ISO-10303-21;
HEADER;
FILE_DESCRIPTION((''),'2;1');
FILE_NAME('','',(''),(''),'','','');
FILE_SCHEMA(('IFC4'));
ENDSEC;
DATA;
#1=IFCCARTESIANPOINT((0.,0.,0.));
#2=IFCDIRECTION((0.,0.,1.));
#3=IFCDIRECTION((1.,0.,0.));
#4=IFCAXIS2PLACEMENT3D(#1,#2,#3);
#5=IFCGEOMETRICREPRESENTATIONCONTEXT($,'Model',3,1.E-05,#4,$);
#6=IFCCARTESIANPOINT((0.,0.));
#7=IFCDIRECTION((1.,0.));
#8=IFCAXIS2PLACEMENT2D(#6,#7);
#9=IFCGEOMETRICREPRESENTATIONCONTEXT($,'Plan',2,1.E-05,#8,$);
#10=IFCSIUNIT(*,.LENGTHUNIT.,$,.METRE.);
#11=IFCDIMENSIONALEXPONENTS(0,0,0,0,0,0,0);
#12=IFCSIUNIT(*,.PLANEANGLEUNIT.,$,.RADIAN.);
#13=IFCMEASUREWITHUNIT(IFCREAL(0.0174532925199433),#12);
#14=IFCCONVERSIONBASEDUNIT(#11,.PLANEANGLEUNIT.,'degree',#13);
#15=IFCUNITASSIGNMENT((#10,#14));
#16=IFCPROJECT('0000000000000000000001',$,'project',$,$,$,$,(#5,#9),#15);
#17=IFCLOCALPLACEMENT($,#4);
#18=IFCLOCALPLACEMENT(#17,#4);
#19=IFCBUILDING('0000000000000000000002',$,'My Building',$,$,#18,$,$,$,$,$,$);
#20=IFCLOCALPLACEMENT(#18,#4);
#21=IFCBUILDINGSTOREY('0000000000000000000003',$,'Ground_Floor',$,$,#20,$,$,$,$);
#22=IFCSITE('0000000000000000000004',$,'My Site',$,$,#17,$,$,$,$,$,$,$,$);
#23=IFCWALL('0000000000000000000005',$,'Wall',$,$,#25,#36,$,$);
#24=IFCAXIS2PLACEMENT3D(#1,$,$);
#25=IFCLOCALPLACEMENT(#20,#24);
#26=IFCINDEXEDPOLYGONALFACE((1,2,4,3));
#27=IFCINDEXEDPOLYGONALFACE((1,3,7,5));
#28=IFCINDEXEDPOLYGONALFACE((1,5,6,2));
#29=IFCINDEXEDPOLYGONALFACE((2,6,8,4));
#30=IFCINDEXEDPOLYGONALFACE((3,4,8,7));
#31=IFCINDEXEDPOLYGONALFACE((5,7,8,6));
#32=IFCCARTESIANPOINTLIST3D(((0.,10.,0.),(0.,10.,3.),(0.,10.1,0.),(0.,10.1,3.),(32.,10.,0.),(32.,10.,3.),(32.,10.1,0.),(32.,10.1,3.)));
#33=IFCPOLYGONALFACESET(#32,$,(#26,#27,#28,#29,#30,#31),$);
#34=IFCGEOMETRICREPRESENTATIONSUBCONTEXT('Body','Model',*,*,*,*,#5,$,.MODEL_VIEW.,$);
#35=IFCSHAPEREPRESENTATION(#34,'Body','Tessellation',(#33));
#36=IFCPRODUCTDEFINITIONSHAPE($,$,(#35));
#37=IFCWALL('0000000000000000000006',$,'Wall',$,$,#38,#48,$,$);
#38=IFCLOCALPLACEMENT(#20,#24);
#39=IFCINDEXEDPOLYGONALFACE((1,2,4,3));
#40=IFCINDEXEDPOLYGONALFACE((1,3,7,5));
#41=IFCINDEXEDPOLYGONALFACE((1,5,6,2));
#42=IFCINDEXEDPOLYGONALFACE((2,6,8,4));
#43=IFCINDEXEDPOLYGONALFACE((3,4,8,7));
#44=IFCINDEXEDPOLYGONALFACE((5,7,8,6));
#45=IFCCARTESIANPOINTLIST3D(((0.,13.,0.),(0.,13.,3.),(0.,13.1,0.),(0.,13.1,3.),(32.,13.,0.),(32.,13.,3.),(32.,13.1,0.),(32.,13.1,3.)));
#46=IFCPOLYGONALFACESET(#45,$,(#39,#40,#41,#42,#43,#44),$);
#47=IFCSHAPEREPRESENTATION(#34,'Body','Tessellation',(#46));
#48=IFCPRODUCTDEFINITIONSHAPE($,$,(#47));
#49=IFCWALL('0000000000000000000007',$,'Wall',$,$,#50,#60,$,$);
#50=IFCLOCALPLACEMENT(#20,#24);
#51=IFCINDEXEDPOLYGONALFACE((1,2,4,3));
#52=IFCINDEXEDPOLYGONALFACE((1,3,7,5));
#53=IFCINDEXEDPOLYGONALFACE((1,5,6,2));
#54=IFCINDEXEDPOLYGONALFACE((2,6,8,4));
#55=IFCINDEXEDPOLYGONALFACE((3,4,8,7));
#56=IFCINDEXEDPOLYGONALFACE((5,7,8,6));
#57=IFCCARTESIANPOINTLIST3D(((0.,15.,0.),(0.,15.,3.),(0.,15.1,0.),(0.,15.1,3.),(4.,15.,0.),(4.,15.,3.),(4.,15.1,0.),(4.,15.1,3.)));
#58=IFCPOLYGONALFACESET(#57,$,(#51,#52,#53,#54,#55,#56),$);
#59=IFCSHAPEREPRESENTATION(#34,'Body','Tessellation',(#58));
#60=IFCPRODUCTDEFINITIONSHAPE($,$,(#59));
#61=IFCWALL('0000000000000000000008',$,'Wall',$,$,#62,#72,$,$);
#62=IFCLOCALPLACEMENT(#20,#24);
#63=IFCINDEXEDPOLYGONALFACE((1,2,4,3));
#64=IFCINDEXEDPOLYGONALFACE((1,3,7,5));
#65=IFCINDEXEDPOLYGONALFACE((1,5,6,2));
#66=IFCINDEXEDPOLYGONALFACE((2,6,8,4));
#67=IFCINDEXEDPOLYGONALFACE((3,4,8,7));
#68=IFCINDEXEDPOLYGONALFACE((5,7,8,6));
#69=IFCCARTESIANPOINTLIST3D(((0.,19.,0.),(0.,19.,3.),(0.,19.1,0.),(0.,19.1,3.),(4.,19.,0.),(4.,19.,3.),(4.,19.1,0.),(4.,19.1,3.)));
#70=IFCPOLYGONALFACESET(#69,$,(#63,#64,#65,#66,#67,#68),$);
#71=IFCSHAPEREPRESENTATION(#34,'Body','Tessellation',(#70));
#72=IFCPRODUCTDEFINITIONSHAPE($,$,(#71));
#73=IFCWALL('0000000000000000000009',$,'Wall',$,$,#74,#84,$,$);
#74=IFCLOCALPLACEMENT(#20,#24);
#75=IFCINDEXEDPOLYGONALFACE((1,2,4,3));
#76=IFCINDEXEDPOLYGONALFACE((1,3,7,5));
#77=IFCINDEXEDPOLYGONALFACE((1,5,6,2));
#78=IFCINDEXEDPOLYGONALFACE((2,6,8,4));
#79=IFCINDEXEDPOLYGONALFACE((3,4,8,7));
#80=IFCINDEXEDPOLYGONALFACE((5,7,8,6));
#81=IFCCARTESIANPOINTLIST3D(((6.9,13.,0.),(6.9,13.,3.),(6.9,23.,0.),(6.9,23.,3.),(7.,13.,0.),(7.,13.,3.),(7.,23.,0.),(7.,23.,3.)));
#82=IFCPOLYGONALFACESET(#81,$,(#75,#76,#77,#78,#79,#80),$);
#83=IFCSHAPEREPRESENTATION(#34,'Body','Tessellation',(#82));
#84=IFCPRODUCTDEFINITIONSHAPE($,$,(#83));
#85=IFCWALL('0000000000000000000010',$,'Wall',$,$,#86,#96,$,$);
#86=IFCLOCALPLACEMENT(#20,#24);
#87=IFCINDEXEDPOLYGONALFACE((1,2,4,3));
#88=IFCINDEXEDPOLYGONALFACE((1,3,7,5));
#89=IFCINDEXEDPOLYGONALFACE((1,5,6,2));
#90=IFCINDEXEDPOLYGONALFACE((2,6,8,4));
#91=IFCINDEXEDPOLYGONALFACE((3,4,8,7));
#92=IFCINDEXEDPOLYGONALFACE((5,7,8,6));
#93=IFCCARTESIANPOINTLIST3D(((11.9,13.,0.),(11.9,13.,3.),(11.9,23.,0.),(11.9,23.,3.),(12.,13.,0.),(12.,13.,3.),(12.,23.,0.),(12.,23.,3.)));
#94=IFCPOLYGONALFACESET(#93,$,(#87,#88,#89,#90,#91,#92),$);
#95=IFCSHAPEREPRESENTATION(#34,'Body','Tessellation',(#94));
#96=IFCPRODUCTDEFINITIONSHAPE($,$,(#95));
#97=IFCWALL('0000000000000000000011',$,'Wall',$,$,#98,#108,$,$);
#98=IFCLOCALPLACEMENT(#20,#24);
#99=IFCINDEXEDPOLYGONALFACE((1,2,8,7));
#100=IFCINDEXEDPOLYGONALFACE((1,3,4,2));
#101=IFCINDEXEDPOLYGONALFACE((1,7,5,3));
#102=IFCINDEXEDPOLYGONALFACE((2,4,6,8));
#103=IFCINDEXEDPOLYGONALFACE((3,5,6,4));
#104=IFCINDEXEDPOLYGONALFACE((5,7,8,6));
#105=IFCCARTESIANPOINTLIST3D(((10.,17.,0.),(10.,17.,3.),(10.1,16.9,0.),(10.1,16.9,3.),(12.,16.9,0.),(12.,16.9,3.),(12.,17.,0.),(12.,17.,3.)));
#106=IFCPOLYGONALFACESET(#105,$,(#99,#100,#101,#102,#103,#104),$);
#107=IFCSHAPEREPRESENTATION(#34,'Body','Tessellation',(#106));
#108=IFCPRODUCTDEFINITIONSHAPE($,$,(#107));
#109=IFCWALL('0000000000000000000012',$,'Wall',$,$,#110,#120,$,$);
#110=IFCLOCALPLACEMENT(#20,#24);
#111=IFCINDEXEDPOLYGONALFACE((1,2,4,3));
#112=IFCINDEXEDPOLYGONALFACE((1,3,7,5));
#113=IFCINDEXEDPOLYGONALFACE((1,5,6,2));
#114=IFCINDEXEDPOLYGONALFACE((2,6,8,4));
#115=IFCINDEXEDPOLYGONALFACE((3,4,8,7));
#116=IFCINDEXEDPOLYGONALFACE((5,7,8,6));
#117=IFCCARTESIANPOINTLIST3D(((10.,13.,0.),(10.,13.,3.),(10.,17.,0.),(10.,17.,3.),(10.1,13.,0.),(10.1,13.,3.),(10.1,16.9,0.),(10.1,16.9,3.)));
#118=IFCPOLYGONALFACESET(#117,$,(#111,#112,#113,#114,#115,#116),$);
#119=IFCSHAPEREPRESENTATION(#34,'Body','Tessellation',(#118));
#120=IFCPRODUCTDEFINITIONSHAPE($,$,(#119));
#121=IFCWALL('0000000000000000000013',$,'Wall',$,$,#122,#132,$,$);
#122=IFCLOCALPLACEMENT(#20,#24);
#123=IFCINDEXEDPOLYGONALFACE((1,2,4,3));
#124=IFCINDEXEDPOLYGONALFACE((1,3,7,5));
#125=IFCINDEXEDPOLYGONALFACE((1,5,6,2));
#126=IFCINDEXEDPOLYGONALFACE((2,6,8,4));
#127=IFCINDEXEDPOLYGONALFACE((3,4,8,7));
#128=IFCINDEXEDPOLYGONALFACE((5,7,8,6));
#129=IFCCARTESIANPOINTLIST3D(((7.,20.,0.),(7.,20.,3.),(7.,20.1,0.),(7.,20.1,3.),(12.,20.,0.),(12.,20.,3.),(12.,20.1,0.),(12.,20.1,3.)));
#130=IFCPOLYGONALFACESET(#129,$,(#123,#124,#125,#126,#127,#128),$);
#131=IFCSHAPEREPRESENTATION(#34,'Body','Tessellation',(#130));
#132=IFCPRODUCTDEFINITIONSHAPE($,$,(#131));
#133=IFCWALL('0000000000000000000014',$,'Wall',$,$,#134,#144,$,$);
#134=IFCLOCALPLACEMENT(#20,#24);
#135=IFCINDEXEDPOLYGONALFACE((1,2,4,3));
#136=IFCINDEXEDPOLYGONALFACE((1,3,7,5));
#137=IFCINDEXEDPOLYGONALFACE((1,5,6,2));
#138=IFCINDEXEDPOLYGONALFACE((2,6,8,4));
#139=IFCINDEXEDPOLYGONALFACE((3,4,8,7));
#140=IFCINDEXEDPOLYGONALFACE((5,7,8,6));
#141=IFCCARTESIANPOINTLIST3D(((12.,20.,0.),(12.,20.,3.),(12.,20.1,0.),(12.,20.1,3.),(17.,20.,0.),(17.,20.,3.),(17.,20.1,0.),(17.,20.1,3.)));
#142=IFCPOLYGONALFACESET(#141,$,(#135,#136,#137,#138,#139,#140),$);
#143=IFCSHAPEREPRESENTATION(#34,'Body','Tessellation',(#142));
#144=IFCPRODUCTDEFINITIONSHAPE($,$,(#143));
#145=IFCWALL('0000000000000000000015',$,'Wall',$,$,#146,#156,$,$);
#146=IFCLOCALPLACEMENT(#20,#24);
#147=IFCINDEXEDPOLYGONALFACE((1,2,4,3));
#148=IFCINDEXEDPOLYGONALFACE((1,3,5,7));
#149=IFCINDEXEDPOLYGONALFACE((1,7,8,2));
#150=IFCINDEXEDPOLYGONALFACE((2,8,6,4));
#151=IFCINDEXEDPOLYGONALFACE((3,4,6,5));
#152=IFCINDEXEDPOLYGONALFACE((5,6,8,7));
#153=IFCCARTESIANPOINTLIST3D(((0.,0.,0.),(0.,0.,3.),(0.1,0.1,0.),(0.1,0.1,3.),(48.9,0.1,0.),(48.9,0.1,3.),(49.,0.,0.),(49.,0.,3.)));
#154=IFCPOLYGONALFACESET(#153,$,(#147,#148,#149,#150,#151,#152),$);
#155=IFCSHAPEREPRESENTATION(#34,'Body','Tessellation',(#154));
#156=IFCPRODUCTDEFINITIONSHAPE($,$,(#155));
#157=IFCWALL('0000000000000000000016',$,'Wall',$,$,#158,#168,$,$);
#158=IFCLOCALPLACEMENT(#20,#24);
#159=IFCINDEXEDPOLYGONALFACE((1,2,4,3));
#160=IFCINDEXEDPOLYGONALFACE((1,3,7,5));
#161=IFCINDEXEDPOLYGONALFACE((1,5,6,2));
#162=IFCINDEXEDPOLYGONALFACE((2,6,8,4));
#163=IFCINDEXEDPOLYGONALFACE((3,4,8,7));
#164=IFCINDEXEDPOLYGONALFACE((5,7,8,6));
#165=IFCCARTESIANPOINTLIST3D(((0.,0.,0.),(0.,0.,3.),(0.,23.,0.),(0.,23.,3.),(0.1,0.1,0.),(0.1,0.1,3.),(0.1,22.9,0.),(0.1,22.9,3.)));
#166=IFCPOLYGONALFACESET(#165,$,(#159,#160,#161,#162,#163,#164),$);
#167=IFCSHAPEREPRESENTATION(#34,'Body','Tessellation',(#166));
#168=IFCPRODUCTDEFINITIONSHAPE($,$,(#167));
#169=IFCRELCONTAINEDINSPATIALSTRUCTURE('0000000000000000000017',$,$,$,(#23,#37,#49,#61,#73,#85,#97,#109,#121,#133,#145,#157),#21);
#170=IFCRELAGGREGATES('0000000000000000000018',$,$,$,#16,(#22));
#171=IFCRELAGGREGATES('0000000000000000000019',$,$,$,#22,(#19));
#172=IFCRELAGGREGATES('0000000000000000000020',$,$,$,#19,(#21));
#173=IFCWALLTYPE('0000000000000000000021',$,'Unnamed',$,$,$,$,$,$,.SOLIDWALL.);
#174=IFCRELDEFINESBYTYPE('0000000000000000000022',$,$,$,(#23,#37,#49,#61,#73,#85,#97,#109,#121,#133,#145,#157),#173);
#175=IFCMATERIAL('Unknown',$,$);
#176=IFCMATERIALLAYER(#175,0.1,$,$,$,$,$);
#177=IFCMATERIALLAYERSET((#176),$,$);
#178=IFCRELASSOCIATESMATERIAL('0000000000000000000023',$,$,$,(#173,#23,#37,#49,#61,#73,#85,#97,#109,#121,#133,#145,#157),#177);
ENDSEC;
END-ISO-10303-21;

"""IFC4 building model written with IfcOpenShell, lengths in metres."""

from ifc_helpers import new_model, entity, si_unit, converted_unit, frame, origin_with_axes, origin_2d_with_axis, place, context, subcontext, project, spatial, line, indexed_curve, outline, extrude, material, layer, layer_set, layer_usage, type_object, element, save


model = new_model("IFC4")

# Units and contexts
model_context = context("Model", 3, precision=1e-05, world=origin_with_axes())
plan_context = context("Plan", 2, precision=1e-05, world=origin_2d_with_axis())
body_context = subcontext(model_context, "Body", "Model", "MODEL_VIEW")
ifc_project = project(units=[si_unit("LENGTHUNIT", "METRE"), converted_unit("PLANEANGLEUNIT", "degree", entity("IfcReal", 0.0174532925199433), si_unit("PLANEANGLEUNIT", "RADIAN"), dimensions=[0, 0, 0, 0, 0, 0, 0])], contexts=[model_context, plan_context])

# Site, building, storey
site_placement = place(None, origin_with_axes())
site = spatial("IfcSite", under=ifc_project, at=site_placement, Name="My Site")
building_placement = place(site_placement, origin_with_axes())
building = spatial("IfcBuilding", under=site, at=building_placement, Name="My Building")
storey_placement = place(building_placement, origin_with_axes())
storey = spatial("IfcBuildingStorey", under=building, at=storey_placement, Name="Ground_Floor")

# Shared definitions
ifc_material = material(Name="Unknown")

# Walls
ifc_layer_1 = layer(ifc_material, 0.1)
ifc_layer_set_1 = layer_set([ifc_layer_1])
wall_type = type_object("IfcWallType", Name="Unnamed", PredefinedType="SOLIDWALL", material=ifc_layer_set_1)
ifc_layer_usage_1 = layer_usage(ifc_layer_set_1, "AXIS2", "POSITIVE", 0.0)
wall_1_placement = place(storey_placement, frame((0.0, 10.0, 0.0), z_axis=(0.0, 0.0, 1.0), x_axis=(1.0, 0.0, 0.0)))
element("IfcWall", 1, at=wall_1_placement, inside=storey, type_object=wall_type, material=ifc_layer_usage_1, Name="Wall", context=body_context, shape_type="SweptSolid", body=[
    extrude(outline(indexed_curve([(0.0, 0.0), (0.0, 0.1), (32.0, 0.1), (32.0, 0.0)], segments=[line(1, 2, 3, 4, 1)])), origin_with_axes(), (0.0, 0.0, 1.0), 3.0),
])
ifc_layer_usage_2 = layer_usage(ifc_layer_set_1, "AXIS2", "POSITIVE", 0.0)
wall_2_placement = place(storey_placement, frame((0.0, 13.0, 0.0), z_axis=(0.0, 0.0, 1.0), x_axis=(1.0, 0.0, 0.0)))
element("IfcWall", 2, at=wall_2_placement, inside=storey, type_object=wall_type, material=ifc_layer_usage_2, Name="Wall", context=body_context, shape_type="SweptSolid", body=[
    extrude(outline(indexed_curve([(0.0, 0.0), (0.0, 0.1), (32.0, 0.1), (32.0, 0.0)], segments=[line(1, 2, 3, 4, 1)])), origin_with_axes(), (0.0, 0.0, 1.0), 3.0),
])
ifc_layer_usage_3 = layer_usage(ifc_layer_set_1, "AXIS2", "POSITIVE", 0.0)
wall_3_placement = place(storey_placement, frame((0.0, 15.0, 0.0), z_axis=(0.0, 0.0, 1.0), x_axis=(1.0, 0.0, 0.0)))
element("IfcWall", 3, at=wall_3_placement, inside=storey, type_object=wall_type, material=ifc_layer_usage_3, Name="Wall", context=body_context, shape_type="SweptSolid", body=[
    extrude(outline(indexed_curve([(0.0, 0.0), (0.0, 0.1), (4.0, 0.1), (4.0, 0.0)], segments=[line(1, 2, 3, 4, 1)])), origin_with_axes(), (0.0, 0.0, 1.0), 3.0),
])
ifc_layer_usage_4 = layer_usage(ifc_layer_set_1, "AXIS2", "POSITIVE", 0.0)
wall_4_placement = place(storey_placement, frame((0.0, 19.0, 0.0), z_axis=(0.0, 0.0, 1.0), x_axis=(1.0, 0.0, 0.0)))
element("IfcWall", 4, at=wall_4_placement, inside=storey, type_object=wall_type, material=ifc_layer_usage_4, Name="Wall", context=body_context, shape_type="SweptSolid", body=[
    extrude(outline(indexed_curve([(0.0, 0.0), (0.0, 0.1), (4.0, 0.1), (4.0, 0.0)], segments=[line(1, 2, 3, 4, 1)])), origin_with_axes(), (0.0, 0.0, 1.0), 3.0),
])
ifc_layer_usage_5 = layer_usage(ifc_layer_set_1, "AXIS2", "POSITIVE", 0.0)
wall_5_placement = place(storey_placement, frame((7.0, 13.0, 0.0), z_axis=(0.0, 0.0, 1.0), x_axis=(0.0, 1.0, 0.0)))
element("IfcWall", 5, at=wall_5_placement, inside=storey, type_object=wall_type, material=ifc_layer_usage_5, Name="Wall", context=body_context, shape_type="SweptSolid", body=[
    extrude(outline(indexed_curve([(0.0, 0.0), (0.0, 0.1), (10.0, 0.1), (10.0, 0.0)], segments=[line(1, 2, 3, 4, 1)])), origin_with_axes(), (0.0, 0.0, 1.0), 3.0),
])
ifc_layer_usage_6 = layer_usage(ifc_layer_set_1, "AXIS2", "POSITIVE", 0.0)
wall_6_placement = place(storey_placement, frame((12.0, 13.0, 0.0), z_axis=(0.0, 0.0, 1.0), x_axis=(0.0, 1.0, 0.0)))
element("IfcWall", 6, at=wall_6_placement, inside=storey, type_object=wall_type, material=ifc_layer_usage_6, Name="Wall", context=body_context, shape_type="SweptSolid", body=[
    extrude(outline(indexed_curve([(0.0, 0.0), (0.0, 0.1), (10.0, 0.1), (10.0, 0.0)], segments=[line(1, 2, 3, 4, 1)])), origin_with_axes(), (0.0, 0.0, 1.0), 3.0),
])
ifc_layer_usage_7 = layer_usage(ifc_layer_set_1, "AXIS2", "POSITIVE", 0.0)
wall_7_placement = place(storey_placement, frame((12.0, 17.0, 0.0), z_axis=(0.0, 0.0, 1.0), x_axis=(-1.0, 0.0, 0.0)))
element("IfcWall", 7, at=wall_7_placement, inside=storey, type_object=wall_type, material=ifc_layer_usage_7, Name="Wall", context=body_context, shape_type="SweptSolid", body=[
    extrude(outline(indexed_curve([(0.0, 0.0), (0.0, 0.1), (1.9, 0.1), (2.0, 0.0)], segments=[line(1, 2, 3, 4, 1)])), origin_with_axes(), (0.0, 0.0, 1.0), 3.0),
])
ifc_layer_usage_8 = layer_usage(ifc_layer_set_1, "AXIS2", "POSITIVE", 0.0)
wall_8_placement = place(storey_placement, frame((10.0, 17.0, 0.0), z_axis=(0.0, 0.0, 1.0), x_axis=(0.0, -1.0, 0.0)))
element("IfcWall", 8, at=wall_8_placement, inside=storey, type_object=wall_type, material=ifc_layer_usage_8, Name="Wall", context=body_context, shape_type="SweptSolid", body=[
    extrude(outline(indexed_curve([(0.0, 0.0), (0.1, 0.1), (4.0, 0.1), (4.0, 0.0)], segments=[line(1, 2, 3, 4, 1)])), origin_with_axes(), (0.0, 0.0, 1.0), 3.0),
])
ifc_layer_usage_9 = layer_usage(ifc_layer_set_1, "AXIS2", "POSITIVE", 0.0)
wall_9_placement = place(storey_placement, frame((7.0, 20.0, 0.0), z_axis=(0.0, 0.0, 1.0), x_axis=(1.0, 0.0, 0.0)))
element("IfcWall", 9, at=wall_9_placement, inside=storey, type_object=wall_type, material=ifc_layer_usage_9, Name="Wall", context=body_context, shape_type="SweptSolid", body=[
    extrude(outline(indexed_curve([(0.0, 0.0), (0.0, 0.1), (5.0, 0.1), (5.0, 0.0)], segments=[line(1, 2, 3, 4, 1)])), origin_with_axes(), (0.0, 0.0, 1.0), 3.0),
])
ifc_layer_usage_10 = layer_usage(ifc_layer_set_1, "AXIS2", "POSITIVE", 0.0)
wall_10_placement = place(storey_placement, frame((12.0, 20.0, 0.0), z_axis=(0.0, 0.0, 1.0), x_axis=(1.0, 0.0, 0.0)))
element("IfcWall", 10, at=wall_10_placement, inside=storey, type_object=wall_type, material=ifc_layer_usage_10, Name="Wall", context=body_context, shape_type="SweptSolid", body=[
    extrude(outline(indexed_curve([(0.0, 0.0), (0.0, 0.1), (5.0, 0.1), (5.0, 0.0)], segments=[line(1, 2, 3, 4, 1)])), origin_with_axes(), (0.0, 0.0, 1.0), 3.0),
])
ifc_layer_usage_11 = layer_usage(ifc_layer_set_1, "AXIS2", "POSITIVE", 0.0)
wall_11_placement = place(storey_placement, frame((0.0, 0.0, 0.0), z_axis=(0.0, 0.0, 1.0), x_axis=(1.0, 0.0, 0.0)))
element("IfcWall", 11, at=wall_11_placement, inside=storey, type_object=wall_type, material=ifc_layer_usage_11, Name="Wall", context=body_context, shape_type="SweptSolid", body=[
    extrude(outline(indexed_curve([(0.0, 0.0), (0.1, 0.1), (48.9, 0.1), (49.0, 0.0)], segments=[line(1, 2, 3, 4, 1)])), origin_with_axes(), (0.0, 0.0, 1.0), 3.0),
])
ifc_layer_usage_12 = layer_usage(ifc_layer_set_1, "AXIS2", "POSITIVE", 0.0)
wall_12_placement = place(storey_placement, frame((0.0, 23.0, 0.0), z_axis=(0.0, 0.0, 1.0), x_axis=(0.0, -1.0, 0.0)))
element("IfcWall", 12, at=wall_12_placement, inside=storey, type_object=wall_type, material=ifc_layer_usage_12, Name="Wall", context=body_context, shape_type="SweptSolid", body=[
    extrude(outline(indexed_curve([(0.0, 0.0), (0.1, 0.1), (22.9, 0.1), (23.0, 0.0)], segments=[line(1, 2, 3, 4, 1)])), origin_with_axes(), (0.0, 0.0, 1.0), 3.0),
])

save(model, "model.ifc")
